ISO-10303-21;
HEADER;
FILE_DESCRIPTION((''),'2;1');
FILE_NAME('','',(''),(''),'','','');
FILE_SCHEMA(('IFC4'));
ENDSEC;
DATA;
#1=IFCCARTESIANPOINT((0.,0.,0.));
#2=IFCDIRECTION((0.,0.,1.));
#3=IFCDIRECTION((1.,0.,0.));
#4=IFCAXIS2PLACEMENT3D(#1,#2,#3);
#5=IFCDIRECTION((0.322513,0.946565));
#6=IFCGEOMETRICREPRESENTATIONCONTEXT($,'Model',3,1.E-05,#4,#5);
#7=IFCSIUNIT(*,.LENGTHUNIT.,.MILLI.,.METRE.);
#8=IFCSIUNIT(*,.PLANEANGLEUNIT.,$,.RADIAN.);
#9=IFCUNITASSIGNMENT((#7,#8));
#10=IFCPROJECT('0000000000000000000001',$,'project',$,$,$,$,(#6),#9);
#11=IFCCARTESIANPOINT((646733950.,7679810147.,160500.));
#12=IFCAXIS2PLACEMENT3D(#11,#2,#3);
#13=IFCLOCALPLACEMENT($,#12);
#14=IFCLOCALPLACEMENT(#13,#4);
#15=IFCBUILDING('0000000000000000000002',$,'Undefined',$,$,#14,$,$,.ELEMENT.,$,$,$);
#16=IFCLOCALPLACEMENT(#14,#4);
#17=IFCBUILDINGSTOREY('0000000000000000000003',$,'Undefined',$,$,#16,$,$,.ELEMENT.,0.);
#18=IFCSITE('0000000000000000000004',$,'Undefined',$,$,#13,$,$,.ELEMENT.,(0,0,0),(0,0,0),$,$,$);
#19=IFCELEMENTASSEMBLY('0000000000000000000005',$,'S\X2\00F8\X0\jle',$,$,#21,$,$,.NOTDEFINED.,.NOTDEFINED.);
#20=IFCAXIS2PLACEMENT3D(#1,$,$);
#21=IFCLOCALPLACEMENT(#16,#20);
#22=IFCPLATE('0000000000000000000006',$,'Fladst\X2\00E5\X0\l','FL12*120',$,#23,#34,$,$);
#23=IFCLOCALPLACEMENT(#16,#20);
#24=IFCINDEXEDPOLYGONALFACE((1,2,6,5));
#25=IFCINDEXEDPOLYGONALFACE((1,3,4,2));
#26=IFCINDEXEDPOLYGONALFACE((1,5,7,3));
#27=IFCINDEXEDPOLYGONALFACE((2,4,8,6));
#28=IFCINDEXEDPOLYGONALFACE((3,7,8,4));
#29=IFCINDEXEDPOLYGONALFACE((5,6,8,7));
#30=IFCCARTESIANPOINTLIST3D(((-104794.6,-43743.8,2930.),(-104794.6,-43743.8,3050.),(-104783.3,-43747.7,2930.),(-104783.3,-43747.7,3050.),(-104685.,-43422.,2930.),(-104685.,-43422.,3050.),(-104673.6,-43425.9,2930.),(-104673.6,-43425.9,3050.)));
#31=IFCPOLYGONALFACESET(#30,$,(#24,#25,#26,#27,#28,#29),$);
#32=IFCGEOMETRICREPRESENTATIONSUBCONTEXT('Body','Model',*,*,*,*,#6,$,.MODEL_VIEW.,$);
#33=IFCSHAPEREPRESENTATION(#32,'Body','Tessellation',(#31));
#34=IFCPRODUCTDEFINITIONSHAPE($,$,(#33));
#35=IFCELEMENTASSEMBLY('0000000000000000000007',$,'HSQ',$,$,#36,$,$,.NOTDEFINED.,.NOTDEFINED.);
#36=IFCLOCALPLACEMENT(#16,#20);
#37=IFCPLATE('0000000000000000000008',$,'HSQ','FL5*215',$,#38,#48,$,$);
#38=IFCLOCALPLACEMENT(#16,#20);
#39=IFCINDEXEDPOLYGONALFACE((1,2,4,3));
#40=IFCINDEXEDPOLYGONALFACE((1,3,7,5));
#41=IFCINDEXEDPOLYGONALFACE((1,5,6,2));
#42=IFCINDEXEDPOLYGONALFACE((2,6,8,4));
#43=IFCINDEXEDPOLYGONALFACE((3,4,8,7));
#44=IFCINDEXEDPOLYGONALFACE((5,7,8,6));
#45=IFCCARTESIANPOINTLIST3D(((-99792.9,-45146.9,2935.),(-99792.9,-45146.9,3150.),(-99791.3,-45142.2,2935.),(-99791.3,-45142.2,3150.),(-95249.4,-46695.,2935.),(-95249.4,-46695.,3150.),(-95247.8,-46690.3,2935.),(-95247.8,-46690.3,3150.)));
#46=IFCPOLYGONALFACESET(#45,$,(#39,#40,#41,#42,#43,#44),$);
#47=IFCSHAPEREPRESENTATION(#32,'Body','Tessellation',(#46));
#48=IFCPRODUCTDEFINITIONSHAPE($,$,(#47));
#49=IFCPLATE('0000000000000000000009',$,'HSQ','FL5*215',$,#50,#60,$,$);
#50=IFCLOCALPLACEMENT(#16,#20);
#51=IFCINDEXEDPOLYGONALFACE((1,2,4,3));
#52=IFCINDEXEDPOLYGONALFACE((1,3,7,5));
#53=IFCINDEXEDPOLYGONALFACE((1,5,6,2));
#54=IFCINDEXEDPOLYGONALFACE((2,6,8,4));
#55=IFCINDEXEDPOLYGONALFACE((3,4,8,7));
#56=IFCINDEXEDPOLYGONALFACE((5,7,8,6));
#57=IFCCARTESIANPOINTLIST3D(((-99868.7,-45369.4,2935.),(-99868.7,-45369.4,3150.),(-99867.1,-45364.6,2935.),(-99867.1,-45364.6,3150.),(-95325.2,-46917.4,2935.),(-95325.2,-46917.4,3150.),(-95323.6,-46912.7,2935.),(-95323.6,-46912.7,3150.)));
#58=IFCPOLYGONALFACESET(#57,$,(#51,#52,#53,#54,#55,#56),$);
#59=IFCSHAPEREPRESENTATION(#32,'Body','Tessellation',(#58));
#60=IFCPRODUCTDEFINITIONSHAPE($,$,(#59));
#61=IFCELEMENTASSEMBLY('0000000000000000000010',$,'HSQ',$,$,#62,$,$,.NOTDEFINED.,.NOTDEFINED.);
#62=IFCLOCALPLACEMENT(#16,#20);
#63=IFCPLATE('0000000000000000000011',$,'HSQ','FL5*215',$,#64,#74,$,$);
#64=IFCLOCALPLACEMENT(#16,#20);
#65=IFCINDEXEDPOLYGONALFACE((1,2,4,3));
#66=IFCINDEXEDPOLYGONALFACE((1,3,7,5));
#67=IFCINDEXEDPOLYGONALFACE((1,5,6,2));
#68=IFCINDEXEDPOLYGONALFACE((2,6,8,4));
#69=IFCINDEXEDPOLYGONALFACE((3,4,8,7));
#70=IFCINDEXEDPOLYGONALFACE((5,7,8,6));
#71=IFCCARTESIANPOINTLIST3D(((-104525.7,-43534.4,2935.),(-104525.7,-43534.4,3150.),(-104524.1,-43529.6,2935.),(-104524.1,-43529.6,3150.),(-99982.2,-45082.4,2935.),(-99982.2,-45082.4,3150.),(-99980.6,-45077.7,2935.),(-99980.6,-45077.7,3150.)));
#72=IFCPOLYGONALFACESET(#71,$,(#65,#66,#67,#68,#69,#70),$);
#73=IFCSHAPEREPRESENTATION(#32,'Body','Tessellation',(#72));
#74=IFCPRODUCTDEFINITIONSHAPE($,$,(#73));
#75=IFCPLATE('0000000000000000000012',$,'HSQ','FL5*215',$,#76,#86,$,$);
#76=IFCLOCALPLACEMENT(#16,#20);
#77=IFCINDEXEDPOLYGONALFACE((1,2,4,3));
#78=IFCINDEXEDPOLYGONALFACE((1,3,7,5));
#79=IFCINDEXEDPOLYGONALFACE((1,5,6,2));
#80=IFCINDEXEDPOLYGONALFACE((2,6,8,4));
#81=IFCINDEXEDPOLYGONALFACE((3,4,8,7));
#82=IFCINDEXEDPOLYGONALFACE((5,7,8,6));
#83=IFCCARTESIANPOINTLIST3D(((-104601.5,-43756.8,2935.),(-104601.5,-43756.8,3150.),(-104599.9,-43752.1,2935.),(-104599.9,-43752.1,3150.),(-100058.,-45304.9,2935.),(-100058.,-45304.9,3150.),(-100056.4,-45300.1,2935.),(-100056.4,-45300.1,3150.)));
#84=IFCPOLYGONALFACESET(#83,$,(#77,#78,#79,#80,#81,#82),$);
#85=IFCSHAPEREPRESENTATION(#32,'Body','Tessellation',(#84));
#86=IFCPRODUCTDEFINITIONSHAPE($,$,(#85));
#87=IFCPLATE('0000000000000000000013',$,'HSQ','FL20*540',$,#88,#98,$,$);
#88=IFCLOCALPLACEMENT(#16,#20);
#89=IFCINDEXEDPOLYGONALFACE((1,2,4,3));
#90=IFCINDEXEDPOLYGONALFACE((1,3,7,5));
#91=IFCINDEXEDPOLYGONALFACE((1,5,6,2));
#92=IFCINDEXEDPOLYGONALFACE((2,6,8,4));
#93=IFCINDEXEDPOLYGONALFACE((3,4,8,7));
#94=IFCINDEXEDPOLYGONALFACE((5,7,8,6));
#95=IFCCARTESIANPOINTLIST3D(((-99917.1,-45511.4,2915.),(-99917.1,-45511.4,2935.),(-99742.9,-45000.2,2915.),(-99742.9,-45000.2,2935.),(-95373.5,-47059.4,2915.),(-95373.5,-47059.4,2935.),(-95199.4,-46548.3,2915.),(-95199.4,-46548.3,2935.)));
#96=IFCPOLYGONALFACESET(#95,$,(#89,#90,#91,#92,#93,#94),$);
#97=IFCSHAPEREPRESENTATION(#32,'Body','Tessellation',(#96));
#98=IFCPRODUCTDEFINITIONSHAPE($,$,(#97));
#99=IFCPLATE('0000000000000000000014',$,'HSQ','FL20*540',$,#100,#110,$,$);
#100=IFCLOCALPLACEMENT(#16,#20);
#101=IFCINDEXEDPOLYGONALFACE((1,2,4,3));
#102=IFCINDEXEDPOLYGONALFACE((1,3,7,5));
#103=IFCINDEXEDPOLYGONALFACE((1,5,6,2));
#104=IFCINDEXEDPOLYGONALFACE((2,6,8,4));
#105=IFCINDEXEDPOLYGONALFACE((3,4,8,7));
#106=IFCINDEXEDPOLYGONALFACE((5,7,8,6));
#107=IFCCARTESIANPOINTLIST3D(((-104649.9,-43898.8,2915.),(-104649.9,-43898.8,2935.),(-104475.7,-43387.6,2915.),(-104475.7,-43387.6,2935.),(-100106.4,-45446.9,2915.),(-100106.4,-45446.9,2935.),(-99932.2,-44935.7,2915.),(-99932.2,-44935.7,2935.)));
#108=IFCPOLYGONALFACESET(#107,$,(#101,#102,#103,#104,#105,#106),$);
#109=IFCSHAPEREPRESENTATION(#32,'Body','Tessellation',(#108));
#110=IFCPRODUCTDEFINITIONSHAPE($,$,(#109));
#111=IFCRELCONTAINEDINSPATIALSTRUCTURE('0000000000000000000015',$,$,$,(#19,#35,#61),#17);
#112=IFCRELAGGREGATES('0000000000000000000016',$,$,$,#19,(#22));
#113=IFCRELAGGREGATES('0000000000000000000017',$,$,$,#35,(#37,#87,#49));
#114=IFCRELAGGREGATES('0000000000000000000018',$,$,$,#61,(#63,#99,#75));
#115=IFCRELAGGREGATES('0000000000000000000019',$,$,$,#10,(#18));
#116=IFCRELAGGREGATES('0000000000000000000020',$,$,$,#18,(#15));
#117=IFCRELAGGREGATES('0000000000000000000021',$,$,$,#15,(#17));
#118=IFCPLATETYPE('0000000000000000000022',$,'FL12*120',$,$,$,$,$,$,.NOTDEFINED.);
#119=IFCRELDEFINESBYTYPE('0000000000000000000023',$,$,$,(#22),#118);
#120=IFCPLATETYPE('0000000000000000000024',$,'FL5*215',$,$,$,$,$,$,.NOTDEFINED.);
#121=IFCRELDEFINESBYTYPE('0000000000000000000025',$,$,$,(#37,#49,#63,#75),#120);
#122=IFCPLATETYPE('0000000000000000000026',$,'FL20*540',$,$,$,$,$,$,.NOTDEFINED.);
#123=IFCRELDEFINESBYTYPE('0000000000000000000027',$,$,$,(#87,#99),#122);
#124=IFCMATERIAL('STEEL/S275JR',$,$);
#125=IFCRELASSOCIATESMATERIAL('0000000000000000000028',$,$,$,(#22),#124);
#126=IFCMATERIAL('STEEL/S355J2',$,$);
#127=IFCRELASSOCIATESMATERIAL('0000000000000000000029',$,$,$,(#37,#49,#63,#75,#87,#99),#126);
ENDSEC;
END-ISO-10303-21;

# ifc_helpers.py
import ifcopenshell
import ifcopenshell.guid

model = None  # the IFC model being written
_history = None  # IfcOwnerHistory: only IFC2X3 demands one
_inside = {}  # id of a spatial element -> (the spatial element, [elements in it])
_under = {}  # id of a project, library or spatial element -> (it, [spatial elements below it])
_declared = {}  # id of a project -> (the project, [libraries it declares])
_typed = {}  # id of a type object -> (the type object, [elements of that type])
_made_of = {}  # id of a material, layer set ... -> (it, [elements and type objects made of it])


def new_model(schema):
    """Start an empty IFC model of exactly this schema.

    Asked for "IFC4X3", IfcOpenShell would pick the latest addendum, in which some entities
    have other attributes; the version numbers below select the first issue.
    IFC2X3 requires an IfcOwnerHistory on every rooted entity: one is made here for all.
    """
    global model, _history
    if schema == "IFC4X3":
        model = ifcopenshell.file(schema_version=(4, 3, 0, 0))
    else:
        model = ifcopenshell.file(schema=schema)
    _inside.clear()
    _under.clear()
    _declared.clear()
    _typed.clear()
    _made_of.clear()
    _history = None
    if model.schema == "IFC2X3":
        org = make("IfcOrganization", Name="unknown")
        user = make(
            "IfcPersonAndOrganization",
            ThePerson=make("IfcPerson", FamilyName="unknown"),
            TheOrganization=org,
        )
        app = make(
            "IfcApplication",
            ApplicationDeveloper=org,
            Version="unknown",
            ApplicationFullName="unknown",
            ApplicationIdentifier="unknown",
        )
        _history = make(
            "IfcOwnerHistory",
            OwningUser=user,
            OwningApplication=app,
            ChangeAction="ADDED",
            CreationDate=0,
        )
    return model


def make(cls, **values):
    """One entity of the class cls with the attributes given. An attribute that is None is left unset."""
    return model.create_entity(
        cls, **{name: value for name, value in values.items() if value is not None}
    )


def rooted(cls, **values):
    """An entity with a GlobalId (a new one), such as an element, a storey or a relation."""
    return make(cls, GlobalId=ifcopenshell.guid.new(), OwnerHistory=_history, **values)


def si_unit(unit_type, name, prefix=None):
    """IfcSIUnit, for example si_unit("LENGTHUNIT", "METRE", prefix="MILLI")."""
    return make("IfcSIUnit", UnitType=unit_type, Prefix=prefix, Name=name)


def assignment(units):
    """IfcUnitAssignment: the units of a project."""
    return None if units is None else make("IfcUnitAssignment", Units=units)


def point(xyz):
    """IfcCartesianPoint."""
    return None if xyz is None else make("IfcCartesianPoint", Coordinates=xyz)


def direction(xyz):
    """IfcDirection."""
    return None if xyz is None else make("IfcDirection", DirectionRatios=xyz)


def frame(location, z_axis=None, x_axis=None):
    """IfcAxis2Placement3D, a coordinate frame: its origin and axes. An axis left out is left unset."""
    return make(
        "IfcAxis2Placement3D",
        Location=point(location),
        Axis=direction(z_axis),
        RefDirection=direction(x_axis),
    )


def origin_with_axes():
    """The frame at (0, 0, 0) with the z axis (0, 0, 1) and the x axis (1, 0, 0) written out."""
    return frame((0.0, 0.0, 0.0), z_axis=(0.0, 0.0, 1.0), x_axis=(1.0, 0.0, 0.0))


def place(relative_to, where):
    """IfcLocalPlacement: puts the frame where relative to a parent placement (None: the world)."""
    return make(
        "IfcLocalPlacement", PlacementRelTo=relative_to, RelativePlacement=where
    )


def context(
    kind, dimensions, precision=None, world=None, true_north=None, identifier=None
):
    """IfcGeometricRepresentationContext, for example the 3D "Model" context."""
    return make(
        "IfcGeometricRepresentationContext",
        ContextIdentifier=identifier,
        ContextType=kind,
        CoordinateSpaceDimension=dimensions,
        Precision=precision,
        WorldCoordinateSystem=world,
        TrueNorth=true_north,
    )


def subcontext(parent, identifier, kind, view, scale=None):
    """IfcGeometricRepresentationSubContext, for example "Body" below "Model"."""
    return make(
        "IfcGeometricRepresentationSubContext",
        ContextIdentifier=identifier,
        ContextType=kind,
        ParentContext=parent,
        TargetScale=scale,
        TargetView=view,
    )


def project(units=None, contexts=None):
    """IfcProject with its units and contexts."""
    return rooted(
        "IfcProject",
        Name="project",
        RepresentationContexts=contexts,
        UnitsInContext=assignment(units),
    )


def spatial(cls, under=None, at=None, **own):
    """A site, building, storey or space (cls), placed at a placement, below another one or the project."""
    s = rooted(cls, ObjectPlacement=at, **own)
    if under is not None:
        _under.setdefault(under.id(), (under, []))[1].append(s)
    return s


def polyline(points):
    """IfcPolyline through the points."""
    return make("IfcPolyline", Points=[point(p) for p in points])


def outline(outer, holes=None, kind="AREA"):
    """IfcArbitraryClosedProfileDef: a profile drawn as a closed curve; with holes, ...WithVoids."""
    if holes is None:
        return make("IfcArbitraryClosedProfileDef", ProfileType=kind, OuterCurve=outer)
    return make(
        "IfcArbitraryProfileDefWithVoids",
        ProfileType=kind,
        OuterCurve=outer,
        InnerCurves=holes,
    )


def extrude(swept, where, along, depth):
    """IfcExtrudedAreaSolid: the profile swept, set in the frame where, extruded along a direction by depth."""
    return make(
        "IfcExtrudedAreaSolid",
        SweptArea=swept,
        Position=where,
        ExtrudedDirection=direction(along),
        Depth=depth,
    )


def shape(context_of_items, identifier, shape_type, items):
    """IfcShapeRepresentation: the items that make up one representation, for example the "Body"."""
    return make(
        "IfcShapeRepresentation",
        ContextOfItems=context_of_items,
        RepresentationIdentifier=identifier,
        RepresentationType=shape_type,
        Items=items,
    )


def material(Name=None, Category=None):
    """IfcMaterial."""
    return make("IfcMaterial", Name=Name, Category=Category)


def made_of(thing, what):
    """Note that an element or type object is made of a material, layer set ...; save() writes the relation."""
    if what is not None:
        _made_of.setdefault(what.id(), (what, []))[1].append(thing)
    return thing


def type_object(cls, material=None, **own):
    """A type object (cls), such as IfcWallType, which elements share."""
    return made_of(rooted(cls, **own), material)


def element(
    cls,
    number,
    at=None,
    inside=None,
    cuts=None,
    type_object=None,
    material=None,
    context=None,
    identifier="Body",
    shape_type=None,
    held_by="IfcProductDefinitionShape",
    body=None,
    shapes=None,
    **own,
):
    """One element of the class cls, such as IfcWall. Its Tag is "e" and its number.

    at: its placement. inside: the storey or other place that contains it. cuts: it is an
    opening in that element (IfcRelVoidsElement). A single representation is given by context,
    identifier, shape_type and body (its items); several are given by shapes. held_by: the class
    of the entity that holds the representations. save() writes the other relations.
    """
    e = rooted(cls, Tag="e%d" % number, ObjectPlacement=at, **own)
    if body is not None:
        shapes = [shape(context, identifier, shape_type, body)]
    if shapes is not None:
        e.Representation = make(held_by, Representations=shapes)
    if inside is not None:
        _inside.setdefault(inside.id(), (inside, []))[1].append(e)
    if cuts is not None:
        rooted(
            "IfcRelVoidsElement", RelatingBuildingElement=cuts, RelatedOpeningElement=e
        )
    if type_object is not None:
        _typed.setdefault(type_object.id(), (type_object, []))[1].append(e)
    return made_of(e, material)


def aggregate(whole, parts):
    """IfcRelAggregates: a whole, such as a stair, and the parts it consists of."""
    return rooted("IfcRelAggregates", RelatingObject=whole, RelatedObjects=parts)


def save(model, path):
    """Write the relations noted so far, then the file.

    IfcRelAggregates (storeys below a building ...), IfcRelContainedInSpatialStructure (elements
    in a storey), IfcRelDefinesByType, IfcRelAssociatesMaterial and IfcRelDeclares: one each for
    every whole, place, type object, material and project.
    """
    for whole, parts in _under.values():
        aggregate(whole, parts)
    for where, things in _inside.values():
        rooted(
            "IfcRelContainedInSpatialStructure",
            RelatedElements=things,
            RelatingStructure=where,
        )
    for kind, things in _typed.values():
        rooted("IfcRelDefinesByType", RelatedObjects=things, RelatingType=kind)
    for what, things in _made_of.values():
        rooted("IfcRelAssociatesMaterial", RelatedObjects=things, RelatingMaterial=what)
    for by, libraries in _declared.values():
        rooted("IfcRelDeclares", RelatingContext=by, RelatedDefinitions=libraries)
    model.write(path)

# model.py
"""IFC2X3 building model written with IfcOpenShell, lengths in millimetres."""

from ifc_helpers import new_model, si_unit, direction, frame, origin_with_axes, place, context, subcontext, project, spatial, polyline, outline, extrude, material, type_object, element, aggregate, save


model = new_model("IFC2X3")

# Units and contexts
model_context = context("Model", 3, precision=1e-05, world=origin_with_axes(), true_north=direction((0.322513, 0.946565)))
body_context = subcontext(model_context, "Body", "Model", "MODEL_VIEW")
ifc_project = project(units=[si_unit("LENGTHUNIT", "METRE", prefix="MILLI"), si_unit("PLANEANGLEUNIT", "RADIAN")], contexts=[model_context])

# Site, building, storey
site_placement = place(None, frame((646733950.0, 7679810147.0, 160500.0), z_axis=(0.0, 0.0, 1.0), x_axis=(1.0, 0.0, 0.0)))
site = spatial("IfcSite", under=ifc_project, at=site_placement, Name="Undefined", CompositionType="ELEMENT", RefLatitude=(0, 0, 0), RefLongitude=(0, 0, 0))
building_placement = place(site_placement, origin_with_axes())
building = spatial("IfcBuilding", under=site, at=building_placement, Name="Undefined", CompositionType="ELEMENT")
storey_placement = place(building_placement, origin_with_axes())
storey = spatial("IfcBuildingStorey", under=building, at=storey_placement, Name="Undefined", CompositionType="ELEMENT", Elevation=0.0)

# Element assembly
assembly_1_placement = place(storey_placement, origin_with_axes())
assembly_1 = element("IfcElementAssembly", 1, at=assembly_1_placement, inside=storey, Name="Søjle", AssemblyPlace="NOTDEFINED", PredefinedType="NOTDEFINED")

# Shared definitions
ifc_material_1 = material(Name="STEEL/S275JR")

# Plate
plate_type_1 = type_object("IfcPlateType", Name="FL12*120", PredefinedType="NOTDEFINED")
plate_1_placement = place(assembly_1_placement, frame((-104679.3, -43423.9, 3050.0), z_axis=(0.946565, -0.322513, 0.0), x_axis=(-0.322513, -0.946565, 0.0)))
plate_1 = element("IfcPlate", 2, at=plate_1_placement, type_object=plate_type_1, material=ifc_material_1, Name="Fladstål", Description="FL12*120", context=body_context, shape_type="SweptSolid", body=[
    extrude(outline(polyline([(0.0, 0.0), (340.0, 0.0), (340.0, 120.0), (0.0, 120.0), (0.0, 0.0)])), frame((0.0, 0.0, -6.0), z_axis=(0.0, 0.0, 1.0), x_axis=(1.0, 0.0, 0.0)), (0.0, 0.0, 1.0), 12.0),
])

# Element assemblies, plates
assembly_2_placement = place(storey_placement, origin_with_axes())
assembly_2 = element("IfcElementAssembly", 3, at=assembly_2_placement, inside=storey, Name="HSQ", AssemblyPlace="NOTDEFINED", PredefinedType="NOTDEFINED")
ifc_material_2 = material(Name="STEEL/S355J2")
plate_type_2 = type_object("IfcPlateType", Name="FL5*215", PredefinedType="NOTDEFINED")
plate_2_placement = place(assembly_2_placement, frame((-99792.1, -45144.6, 3042.5), z_axis=(-0.322513, -0.946565, 0.0), x_axis=(0.946565, -0.322513, 0.0)))
plate_2 = element("IfcPlate", 4, at=plate_2_placement, type_object=plate_type_2, material=ifc_material_2, Name="HSQ", Description="FL5*215", context=body_context, shape_type="SweptSolid", body=[
    extrude(outline(polyline([(0.0, -107.5), (0.0, 107.5), (4800.0, 107.5), (4800.0, -107.5), (0.0, -107.5)])), frame((0.0, 0.0, -2.5), z_axis=(0.0, 0.0, 1.0), x_axis=(1.0, 0.0, 0.0)), (0.0, 0.0, 1.0), 5.0),
])
plate_3_placement = place(assembly_2_placement, frame((-99867.9, -45367.0, 3042.5), z_axis=(-0.322513, -0.946565, 0.0), x_axis=(0.946565, -0.322513, 0.0)))
plate_3 = element("IfcPlate", 5, at=plate_3_placement, type_object=plate_type_2, material=ifc_material_2, Name="HSQ", Description="FL5*215", context=body_context, shape_type="SweptSolid", body=[
    extrude(outline(polyline([(0.0, -107.5), (0.0, 107.5), (4800.0, 107.5), (4800.0, -107.5), (0.0, -107.5)])), frame((0.0, 0.0, -2.5), z_axis=(0.0, 0.0, 1.0), x_axis=(1.0, 0.0, 0.0)), (0.0, 0.0, 1.0), 5.0),
])
assembly_3_placement = place(storey_placement, origin_with_axes())
assembly_3 = element("IfcElementAssembly", 6, at=assembly_3_placement, inside=storey, Name="HSQ", AssemblyPlace="NOTDEFINED", PredefinedType="NOTDEFINED")
plate_4_placement = place(assembly_3_placement, frame((-104524.9, -43532.0, 3042.5), z_axis=(-0.322513, -0.946565, 0.0), x_axis=(0.946565, -0.322513, 0.0)))
plate_4 = element("IfcPlate", 7, at=plate_4_placement, type_object=plate_type_2, material=ifc_material_2, Name="HSQ", Description="FL5*215", context=body_context, shape_type="SweptSolid", body=[
    extrude(outline(polyline([(0.0, -107.5), (0.0, 107.5), (4800.0, 107.5), (4800.0, -107.5), (0.0, -107.5)])), frame((0.0, 0.0, -2.5), z_axis=(0.0, 0.0, 1.0), x_axis=(1.0, 0.0, 0.0)), (0.0, 0.0, 1.0), 5.0),
])
plate_5_placement = place(assembly_3_placement, frame((-104600.7, -43754.4, 3042.5), z_axis=(-0.322513, -0.946565, 0.0), x_axis=(0.946565, -0.322513, 0.0)))
plate_5 = element("IfcPlate", 8, at=plate_5_placement, type_object=plate_type_2, material=ifc_material_2, Name="HSQ", Description="FL5*215", context=body_context, shape_type="SweptSolid", body=[
    extrude(outline(polyline([(0.0, -107.5), (0.0, 107.5), (4800.0, 107.5), (4800.0, -107.5), (0.0, -107.5)])), frame((0.0, 0.0, -2.5), z_axis=(0.0, 0.0, 1.0), x_axis=(1.0, 0.0, 0.0)), (0.0, 0.0, 1.0), 5.0),
])

# Plates
plate_type_3 = type_object("IfcPlateType", Name="FL20*540", PredefinedType="NOTDEFINED")
plate_6_placement = place(assembly_2_placement, frame((-99830.0, -45255.8, 2925.0), z_axis=(0.0, 0.0, 1.0), x_axis=(0.946565, -0.322513, 0.0)))
plate_6 = element("IfcPlate", 9, at=plate_6_placement, type_object=plate_type_3, material=ifc_material_2, Name="HSQ", Description="FL20*540", context=body_context, shape_type="SweptSolid", body=[
    extrude(outline(polyline([(0.0, -270.0), (0.0, 270.0), (4800.0, 270.0), (4800.0, -270.0), (0.0, -270.0)])), frame((0.0, 0.0, -10.0), z_axis=(0.0, 0.0, 1.0), x_axis=(1.0, 0.0, 0.0)), (0.0, 0.0, 1.0), 20.0),
])
plate_7_placement = place(assembly_3_placement, frame((-104562.8, -43643.2, 2925.0), z_axis=(0.0, 0.0, 1.0), x_axis=(0.946565, -0.322513, 0.0)))
plate_7 = element("IfcPlate", 10, at=plate_7_placement, type_object=plate_type_3, material=ifc_material_2, Name="HSQ", Description="FL20*540", context=body_context, shape_type="SweptSolid", body=[
    extrude(outline(polyline([(0.0, -270.0), (0.0, 270.0), (4800.0, 270.0), (4800.0, -270.0), (0.0, -270.0)])), frame((0.0, 0.0, -10.0), z_axis=(0.0, 0.0, 1.0), x_axis=(1.0, 0.0, 0.0)), (0.0, 0.0, 1.0), 20.0),
])

aggregate(assembly_1, [plate_1])
aggregate(assembly_2, [plate_2, plate_6, plate_3])
aggregate(assembly_3, [plate_4, plate_7, plate_5])

save(model, "model.ifc")
